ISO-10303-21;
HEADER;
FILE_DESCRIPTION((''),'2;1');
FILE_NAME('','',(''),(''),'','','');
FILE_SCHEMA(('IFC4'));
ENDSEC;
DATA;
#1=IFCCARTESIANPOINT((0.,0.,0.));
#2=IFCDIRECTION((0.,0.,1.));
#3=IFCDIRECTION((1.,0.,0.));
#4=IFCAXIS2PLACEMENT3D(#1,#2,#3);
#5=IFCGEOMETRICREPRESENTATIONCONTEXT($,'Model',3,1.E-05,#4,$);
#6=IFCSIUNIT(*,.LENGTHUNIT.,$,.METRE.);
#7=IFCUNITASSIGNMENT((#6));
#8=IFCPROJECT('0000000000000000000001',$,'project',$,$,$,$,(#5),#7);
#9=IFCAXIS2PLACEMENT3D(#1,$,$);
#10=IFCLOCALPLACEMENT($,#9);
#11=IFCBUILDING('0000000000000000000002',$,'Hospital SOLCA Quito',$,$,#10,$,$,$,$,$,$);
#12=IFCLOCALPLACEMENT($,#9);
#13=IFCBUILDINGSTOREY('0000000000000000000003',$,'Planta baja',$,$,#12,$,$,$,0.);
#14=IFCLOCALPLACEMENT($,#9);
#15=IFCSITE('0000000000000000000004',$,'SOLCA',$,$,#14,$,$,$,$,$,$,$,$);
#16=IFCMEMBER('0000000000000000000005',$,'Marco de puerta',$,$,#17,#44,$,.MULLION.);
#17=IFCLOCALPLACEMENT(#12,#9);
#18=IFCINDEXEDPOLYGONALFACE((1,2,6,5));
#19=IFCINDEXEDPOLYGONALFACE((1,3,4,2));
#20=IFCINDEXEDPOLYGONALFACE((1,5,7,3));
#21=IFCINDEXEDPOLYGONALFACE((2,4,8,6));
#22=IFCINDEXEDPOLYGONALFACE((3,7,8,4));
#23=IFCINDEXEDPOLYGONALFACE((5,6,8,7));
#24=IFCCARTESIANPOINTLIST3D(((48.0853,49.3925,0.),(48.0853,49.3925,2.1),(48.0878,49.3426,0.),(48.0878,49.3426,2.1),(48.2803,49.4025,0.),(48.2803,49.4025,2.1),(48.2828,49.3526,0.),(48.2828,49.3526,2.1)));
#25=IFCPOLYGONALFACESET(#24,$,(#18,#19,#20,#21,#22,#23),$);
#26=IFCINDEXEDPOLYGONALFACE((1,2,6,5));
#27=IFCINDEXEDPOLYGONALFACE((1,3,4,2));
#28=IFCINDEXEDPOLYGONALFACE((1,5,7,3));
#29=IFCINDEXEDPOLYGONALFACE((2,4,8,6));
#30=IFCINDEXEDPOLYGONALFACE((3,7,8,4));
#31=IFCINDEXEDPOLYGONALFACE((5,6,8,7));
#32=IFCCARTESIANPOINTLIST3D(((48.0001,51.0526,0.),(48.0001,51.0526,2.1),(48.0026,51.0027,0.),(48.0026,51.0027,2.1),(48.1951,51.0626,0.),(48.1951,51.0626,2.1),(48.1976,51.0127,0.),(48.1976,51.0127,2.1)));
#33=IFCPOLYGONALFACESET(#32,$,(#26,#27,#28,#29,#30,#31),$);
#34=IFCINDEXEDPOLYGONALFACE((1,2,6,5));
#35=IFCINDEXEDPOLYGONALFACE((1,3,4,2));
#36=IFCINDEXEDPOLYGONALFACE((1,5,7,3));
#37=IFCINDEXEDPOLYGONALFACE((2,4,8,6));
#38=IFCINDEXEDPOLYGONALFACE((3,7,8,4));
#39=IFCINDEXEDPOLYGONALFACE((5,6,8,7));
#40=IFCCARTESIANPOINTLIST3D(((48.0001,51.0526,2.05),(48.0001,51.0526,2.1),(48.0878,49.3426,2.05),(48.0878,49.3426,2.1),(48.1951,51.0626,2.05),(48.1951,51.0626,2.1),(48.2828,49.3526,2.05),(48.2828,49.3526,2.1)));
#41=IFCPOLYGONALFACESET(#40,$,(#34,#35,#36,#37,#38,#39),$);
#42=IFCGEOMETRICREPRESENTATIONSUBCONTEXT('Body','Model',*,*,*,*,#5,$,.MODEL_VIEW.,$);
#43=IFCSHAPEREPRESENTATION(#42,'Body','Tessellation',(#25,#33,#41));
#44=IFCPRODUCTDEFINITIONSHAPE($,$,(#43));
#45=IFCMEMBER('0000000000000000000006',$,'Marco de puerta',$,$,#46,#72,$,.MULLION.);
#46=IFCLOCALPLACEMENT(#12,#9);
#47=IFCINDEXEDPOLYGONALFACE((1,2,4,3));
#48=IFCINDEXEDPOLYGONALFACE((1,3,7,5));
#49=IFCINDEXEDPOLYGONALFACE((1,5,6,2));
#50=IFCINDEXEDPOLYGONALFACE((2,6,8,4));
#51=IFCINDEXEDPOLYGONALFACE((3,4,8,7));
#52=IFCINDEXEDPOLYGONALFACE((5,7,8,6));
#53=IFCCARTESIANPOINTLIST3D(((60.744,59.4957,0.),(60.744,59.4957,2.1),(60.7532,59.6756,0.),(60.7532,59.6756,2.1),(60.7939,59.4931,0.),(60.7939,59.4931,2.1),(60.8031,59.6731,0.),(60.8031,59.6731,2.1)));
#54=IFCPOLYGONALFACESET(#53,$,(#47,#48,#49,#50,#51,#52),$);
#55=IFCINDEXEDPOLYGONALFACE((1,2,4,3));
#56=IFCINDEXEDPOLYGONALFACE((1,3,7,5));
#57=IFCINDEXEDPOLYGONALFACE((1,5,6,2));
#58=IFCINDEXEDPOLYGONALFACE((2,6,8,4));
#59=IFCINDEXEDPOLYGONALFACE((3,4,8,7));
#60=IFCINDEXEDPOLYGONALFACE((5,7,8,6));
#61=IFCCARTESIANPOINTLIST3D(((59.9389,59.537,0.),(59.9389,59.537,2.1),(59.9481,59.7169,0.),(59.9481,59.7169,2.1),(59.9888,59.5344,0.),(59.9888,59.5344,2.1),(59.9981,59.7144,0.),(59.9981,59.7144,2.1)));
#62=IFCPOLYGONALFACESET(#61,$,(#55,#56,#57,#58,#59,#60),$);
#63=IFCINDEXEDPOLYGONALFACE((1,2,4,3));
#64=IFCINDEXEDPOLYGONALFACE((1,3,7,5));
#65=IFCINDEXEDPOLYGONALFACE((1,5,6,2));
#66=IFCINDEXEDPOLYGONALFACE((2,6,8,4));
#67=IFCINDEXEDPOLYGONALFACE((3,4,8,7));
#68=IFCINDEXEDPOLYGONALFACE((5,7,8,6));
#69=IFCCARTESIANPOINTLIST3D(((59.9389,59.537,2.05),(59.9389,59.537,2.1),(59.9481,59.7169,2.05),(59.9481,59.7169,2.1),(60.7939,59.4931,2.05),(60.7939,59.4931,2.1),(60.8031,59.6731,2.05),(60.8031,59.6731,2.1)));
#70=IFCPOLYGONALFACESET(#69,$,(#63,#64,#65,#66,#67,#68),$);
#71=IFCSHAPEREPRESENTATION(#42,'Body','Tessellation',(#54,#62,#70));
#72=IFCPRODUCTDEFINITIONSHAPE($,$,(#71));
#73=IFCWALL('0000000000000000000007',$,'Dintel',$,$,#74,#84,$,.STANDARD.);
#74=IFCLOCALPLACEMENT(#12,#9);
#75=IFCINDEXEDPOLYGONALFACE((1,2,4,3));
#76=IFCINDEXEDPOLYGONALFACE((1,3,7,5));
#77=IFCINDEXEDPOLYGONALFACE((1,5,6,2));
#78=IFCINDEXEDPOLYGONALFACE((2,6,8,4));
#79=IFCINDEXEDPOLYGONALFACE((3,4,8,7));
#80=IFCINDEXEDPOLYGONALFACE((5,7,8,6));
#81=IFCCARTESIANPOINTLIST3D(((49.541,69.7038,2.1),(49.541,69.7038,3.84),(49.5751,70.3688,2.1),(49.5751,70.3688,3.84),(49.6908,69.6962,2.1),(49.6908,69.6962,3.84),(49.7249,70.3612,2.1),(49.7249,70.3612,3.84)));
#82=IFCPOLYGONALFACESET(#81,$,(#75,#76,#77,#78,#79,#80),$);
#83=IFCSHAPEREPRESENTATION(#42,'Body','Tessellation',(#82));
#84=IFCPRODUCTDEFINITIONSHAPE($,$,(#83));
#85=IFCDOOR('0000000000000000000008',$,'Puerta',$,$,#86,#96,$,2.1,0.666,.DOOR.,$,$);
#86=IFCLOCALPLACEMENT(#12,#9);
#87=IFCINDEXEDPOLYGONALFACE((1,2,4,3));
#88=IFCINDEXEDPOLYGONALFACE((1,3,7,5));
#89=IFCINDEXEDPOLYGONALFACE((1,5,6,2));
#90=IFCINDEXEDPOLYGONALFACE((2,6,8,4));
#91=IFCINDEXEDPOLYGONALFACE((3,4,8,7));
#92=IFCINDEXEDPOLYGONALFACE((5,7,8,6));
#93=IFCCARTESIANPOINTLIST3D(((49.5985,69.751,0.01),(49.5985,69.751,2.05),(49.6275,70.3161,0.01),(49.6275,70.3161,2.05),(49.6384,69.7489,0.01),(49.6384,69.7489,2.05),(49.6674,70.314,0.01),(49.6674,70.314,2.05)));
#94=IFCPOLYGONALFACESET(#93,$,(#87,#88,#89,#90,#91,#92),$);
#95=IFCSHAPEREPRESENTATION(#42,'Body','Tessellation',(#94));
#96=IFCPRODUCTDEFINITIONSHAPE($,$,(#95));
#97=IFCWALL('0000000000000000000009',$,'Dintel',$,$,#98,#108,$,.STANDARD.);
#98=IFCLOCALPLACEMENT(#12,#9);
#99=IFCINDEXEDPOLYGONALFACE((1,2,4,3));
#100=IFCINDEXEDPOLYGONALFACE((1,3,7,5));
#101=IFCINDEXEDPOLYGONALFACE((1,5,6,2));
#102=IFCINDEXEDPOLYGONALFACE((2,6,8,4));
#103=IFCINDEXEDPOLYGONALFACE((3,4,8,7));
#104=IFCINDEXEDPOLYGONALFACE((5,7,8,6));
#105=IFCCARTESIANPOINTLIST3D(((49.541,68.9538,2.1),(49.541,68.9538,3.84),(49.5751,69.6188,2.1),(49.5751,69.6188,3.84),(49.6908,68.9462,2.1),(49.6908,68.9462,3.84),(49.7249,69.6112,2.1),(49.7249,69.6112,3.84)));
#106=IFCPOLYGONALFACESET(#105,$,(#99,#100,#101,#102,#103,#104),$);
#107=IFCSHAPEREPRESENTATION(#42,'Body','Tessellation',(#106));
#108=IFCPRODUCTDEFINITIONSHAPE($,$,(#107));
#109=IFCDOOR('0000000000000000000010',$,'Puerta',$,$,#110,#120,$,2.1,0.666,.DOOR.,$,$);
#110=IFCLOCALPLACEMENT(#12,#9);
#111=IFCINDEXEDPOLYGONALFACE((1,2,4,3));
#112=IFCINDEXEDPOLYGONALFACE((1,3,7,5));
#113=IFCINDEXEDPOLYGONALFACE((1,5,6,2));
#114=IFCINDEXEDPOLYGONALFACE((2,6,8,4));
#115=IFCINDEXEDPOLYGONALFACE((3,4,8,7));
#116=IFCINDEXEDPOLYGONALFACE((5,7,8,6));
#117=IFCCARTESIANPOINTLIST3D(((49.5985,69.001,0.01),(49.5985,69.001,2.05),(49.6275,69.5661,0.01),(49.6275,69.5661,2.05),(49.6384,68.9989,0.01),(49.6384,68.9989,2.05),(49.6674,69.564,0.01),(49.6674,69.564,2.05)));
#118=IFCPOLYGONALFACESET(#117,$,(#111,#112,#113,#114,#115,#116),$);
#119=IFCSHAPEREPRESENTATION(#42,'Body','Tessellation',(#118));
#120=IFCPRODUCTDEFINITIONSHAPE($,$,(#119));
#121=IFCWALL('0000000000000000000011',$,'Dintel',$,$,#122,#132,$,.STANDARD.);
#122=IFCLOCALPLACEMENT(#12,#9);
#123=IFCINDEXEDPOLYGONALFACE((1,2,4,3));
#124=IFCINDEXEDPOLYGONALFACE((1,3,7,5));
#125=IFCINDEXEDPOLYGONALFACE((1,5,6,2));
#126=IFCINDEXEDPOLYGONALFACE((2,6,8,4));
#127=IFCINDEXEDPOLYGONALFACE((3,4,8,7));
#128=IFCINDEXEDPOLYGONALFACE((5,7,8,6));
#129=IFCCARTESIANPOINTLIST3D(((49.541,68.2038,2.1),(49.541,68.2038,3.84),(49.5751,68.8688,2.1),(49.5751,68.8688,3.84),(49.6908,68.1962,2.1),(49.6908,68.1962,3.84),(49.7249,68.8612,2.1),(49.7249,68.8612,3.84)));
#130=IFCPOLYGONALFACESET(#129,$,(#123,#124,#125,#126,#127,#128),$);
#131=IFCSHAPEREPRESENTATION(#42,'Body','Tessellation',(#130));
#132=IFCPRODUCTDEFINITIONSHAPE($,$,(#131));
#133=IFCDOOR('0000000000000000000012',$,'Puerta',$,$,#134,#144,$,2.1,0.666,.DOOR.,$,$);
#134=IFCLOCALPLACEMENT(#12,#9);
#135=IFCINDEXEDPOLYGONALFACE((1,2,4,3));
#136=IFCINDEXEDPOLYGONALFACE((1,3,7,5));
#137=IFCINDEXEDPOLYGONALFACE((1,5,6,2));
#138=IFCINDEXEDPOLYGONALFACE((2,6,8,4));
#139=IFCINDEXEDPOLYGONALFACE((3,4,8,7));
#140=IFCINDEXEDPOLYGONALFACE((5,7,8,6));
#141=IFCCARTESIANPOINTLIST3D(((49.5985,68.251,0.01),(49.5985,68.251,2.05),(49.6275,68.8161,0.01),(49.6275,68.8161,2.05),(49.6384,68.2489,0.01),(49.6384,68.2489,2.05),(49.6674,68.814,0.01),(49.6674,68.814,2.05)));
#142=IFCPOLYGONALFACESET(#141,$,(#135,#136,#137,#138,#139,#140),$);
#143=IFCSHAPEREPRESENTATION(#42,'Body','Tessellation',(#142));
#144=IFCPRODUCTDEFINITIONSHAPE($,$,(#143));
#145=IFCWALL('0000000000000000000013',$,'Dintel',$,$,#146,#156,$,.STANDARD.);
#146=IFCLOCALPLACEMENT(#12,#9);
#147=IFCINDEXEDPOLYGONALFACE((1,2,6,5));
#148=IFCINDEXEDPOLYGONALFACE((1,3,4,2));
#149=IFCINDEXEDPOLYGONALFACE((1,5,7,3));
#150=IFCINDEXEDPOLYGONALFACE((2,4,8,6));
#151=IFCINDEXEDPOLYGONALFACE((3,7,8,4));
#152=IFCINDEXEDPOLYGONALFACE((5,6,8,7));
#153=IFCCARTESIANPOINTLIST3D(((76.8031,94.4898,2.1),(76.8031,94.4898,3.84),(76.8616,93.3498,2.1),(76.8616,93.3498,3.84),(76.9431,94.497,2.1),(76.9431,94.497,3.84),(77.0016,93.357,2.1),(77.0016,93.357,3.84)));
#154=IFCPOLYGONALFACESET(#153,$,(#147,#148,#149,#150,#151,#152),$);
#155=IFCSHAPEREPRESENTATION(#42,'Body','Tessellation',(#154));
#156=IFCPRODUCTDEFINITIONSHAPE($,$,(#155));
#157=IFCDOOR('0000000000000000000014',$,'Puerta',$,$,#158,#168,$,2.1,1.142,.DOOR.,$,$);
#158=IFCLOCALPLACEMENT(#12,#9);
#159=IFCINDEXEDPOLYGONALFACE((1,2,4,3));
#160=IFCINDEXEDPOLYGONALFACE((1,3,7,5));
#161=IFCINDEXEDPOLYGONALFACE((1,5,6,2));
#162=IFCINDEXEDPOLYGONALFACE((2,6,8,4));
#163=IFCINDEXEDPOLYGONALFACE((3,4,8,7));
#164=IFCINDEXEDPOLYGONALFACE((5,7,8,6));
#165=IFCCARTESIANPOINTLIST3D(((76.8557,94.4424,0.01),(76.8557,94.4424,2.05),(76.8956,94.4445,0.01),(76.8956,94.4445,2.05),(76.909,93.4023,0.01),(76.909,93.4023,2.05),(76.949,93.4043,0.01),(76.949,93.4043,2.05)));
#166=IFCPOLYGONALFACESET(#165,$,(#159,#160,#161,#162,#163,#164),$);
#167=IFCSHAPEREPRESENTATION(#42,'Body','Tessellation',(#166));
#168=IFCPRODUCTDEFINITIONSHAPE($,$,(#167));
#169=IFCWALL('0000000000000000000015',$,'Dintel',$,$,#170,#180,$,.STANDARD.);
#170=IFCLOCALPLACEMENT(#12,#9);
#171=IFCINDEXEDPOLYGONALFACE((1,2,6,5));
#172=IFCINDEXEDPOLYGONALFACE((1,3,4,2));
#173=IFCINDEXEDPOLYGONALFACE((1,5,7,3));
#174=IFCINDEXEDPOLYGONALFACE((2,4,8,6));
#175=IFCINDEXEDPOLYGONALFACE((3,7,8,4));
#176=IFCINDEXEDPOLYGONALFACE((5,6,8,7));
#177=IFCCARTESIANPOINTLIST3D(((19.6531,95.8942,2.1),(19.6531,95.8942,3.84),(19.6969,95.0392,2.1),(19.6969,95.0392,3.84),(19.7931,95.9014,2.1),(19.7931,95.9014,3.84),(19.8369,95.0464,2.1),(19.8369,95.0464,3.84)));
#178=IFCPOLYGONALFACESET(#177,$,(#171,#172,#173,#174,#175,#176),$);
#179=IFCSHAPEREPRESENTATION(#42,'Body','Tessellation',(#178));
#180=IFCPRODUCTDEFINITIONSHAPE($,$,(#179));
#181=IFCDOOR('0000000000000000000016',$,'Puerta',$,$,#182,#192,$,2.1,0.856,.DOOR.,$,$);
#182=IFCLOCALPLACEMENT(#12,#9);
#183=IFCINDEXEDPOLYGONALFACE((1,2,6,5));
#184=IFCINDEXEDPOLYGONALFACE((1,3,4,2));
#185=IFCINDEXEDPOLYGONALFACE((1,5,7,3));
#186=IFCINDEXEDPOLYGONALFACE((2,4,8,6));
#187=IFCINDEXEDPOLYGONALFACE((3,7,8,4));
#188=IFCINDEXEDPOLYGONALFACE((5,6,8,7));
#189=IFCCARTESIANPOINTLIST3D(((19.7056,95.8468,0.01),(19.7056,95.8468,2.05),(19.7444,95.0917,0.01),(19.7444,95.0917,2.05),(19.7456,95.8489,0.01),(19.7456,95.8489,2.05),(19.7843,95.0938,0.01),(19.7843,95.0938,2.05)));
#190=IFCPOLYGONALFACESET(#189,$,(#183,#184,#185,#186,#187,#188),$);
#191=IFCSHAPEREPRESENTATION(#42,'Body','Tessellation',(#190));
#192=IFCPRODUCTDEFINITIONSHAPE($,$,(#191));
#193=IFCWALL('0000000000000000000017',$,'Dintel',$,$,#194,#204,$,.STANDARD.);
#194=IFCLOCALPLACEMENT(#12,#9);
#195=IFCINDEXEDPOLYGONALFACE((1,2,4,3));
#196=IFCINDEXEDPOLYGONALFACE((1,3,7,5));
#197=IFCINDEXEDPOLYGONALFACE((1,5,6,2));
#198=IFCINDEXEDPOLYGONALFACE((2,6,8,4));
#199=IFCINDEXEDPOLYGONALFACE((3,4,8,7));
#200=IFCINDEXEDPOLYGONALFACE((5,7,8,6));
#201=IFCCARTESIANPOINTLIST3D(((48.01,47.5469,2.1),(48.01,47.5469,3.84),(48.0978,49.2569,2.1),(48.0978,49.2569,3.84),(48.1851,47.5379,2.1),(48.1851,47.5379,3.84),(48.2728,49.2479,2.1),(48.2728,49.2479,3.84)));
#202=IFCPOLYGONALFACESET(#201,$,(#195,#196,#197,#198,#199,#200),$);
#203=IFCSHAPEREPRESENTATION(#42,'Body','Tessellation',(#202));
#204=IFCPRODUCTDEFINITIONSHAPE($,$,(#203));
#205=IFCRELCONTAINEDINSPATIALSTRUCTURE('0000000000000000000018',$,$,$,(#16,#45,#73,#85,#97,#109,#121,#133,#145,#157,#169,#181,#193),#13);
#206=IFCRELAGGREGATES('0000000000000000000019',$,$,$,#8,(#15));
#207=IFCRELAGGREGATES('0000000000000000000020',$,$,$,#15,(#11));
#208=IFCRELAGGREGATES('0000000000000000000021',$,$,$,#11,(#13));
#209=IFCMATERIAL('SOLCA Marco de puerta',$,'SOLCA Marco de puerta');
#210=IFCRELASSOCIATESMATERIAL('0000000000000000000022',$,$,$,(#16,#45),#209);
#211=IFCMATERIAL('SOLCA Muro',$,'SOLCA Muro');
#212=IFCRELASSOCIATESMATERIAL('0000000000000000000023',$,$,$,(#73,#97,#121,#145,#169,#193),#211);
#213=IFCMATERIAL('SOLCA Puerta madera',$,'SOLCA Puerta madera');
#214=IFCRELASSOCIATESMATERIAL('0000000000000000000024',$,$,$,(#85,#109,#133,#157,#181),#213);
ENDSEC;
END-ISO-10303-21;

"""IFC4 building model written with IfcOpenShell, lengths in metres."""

from ifc_helpers import new_model, si_unit, frame, origin, origin_with_axes, place, context, subcontext, project, spatial, polyline, outline, extrude, material, element, save


model = new_model("IFC4")

# Units and contexts
model_context = context("Model", 3, precision=1e-05, world=origin_with_axes())
body_context = subcontext(model_context, "Body", "Model", "MODEL_VIEW")
ifc_project = project(units=[si_unit("LENGTHUNIT", "METRE")], contexts=[model_context])

# Site, building, storey
site_placement = place(None, origin())
site = spatial("IfcSite", under=ifc_project, at=site_placement, Name="SOLCA")
building_placement = place(None, origin())
building = spatial("IfcBuilding", under=site, at=building_placement, Name="Hospital SOLCA Quito")
storey_placement = place(None, origin())
storey = spatial("IfcBuildingStorey", under=building, at=storey_placement, Name="Planta baja", Elevation=0.0)

# Members
ifc_material_1 = material(Name="SOLCA Marco de puerta", Category="SOLCA Marco de puerta")
member_1_placement = place(storey_placement, origin_with_axes())
element("IfcMember", 1, at=member_1_placement, inside=storey, material=ifc_material_1, Name="Marco de puerta", PredefinedType="MULLION", context=body_context, shape_type="SweptSolid", body=[
    extrude(outline(polyline([(48.2828, 49.3526), (48.2803, 49.4025), (48.0853, 49.3925), (48.0878, 49.3426), (48.2828, 49.3526)])), origin_with_axes(), (0.0, 0.0, 1.0), 2.1),
    extrude(outline(polyline([(48.1976, 51.0127), (48.1951, 51.0626), (48.0001, 51.0526), (48.0026, 51.0027), (48.1976, 51.0127)])), origin_with_axes(), (0.0, 0.0, 1.0), 2.1),
    extrude(outline(polyline([(48.2828, 49.3526), (48.1951, 51.0626), (48.0001, 51.0526), (48.0878, 49.3426), (48.2828, 49.3526)])), frame((0.0, 0.0, 2.05), z_axis=(0.0, 0.0, 1.0), x_axis=(1.0, 0.0, 0.0)), (0.0, 0.0, 1.0), 0.05),
])
member_2_placement = place(storey_placement, origin_with_axes())
element("IfcMember", 2, at=member_2_placement, inside=storey, material=ifc_material_1, Name="Marco de puerta", PredefinedType="MULLION", context=body_context, shape_type="SweptSolid", body=[
    extrude(outline(polyline([(60.8031, 59.6731), (60.7532, 59.6756), (60.744, 59.4957), (60.7939, 59.4931), (60.8031, 59.6731)])), origin_with_axes(), (0.0, 0.0, 1.0), 2.1),
    extrude(outline(polyline([(59.9981, 59.7144), (59.9481, 59.7169), (59.9389, 59.537), (59.9888, 59.5344), (59.9981, 59.7144)])), origin_with_axes(), (0.0, 0.0, 1.0), 2.1),
    extrude(outline(polyline([(60.8031, 59.6731), (59.9481, 59.7169), (59.9389, 59.537), (60.7939, 59.4931), (60.8031, 59.6731)])), frame((0.0, 0.0, 2.05), z_axis=(0.0, 0.0, 1.0), x_axis=(1.0, 0.0, 0.0)), (0.0, 0.0, 1.0), 0.05),
])

# Wall
ifc_material_2 = material(Name="SOLCA Muro", Category="SOLCA Muro")
wall_1_placement = place(storey_placement, origin_with_axes())
element("IfcWall", 3, at=wall_1_placement, inside=storey, material=ifc_material_2, Name="Dintel", PredefinedType="STANDARD", context=body_context, shape_type="SweptSolid", body=[
    extrude(outline(polyline([(49.5751, 70.3688), (49.541, 69.7038), (49.6908, 69.6962), (49.7249, 70.3612), (49.5751, 70.3688)])), frame((0.0, 0.0, 2.1), z_axis=(0.0, 0.0, 1.0), x_axis=(1.0, 0.0, 0.0)), (0.0, 0.0, 1.0), 1.74),
])

# Door
ifc_material_3 = material(Name="SOLCA Puerta madera", Category="SOLCA Puerta madera")
door_1_placement = place(storey_placement, origin_with_axes())
element("IfcDoor", 4, at=door_1_placement, inside=storey, material=ifc_material_3, Name="Puerta", OverallHeight=2.1, OverallWidth=0.666, PredefinedType="DOOR", context=body_context, shape_type="SweptSolid", body=[
    extrude(outline(polyline([(49.6275, 70.3161), (49.5985, 69.751), (49.6384, 69.7489), (49.6674, 70.314), (49.6275, 70.3161)])), frame((0.0, 0.0, 0.01), z_axis=(0.0, 0.0, 1.0), x_axis=(1.0, 0.0, 0.0)), (0.0, 0.0, 1.0), 2.04),
])

# Wall
wall_2_placement = place(storey_placement, origin_with_axes())
element("IfcWall", 5, at=wall_2_placement, inside=storey, material=ifc_material_2, Name="Dintel", PredefinedType="STANDARD", context=body_context, shape_type="SweptSolid", body=[
    extrude(outline(polyline([(49.5751, 69.6188), (49.541, 68.9538), (49.6908, 68.9462), (49.7249, 69.6112), (49.5751, 69.6188)])), frame((0.0, 0.0, 2.1), z_axis=(0.0, 0.0, 1.0), x_axis=(1.0, 0.0, 0.0)), (0.0, 0.0, 1.0), 1.74),
])

# Door
door_2_placement = place(storey_placement, origin_with_axes())
element("IfcDoor", 6, at=door_2_placement, inside=storey, material=ifc_material_3, Name="Puerta", OverallHeight=2.1, OverallWidth=0.666, PredefinedType="DOOR", context=body_context, shape_type="SweptSolid", body=[
    extrude(outline(polyline([(49.6275, 69.5661), (49.5985, 69.001), (49.6384, 68.9989), (49.6674, 69.564), (49.6275, 69.5661)])), frame((0.0, 0.0, 0.01), z_axis=(0.0, 0.0, 1.0), x_axis=(1.0, 0.0, 0.0)), (0.0, 0.0, 1.0), 2.04),
])

# Wall
wall_3_placement = place(storey_placement, origin_with_axes())
element("IfcWall", 7, at=wall_3_placement, inside=storey, material=ifc_material_2, Name="Dintel", PredefinedType="STANDARD", context=body_context, shape_type="SweptSolid", body=[
    extrude(outline(polyline([(49.5751, 68.8688), (49.541, 68.2038), (49.6908, 68.1962), (49.7249, 68.8612), (49.5751, 68.8688)])), frame((0.0, 0.0, 2.1), z_axis=(0.0, 0.0, 1.0), x_axis=(1.0, 0.0, 0.0)), (0.0, 0.0, 1.0), 1.74),
])

# Door
door_3_placement = place(storey_placement, origin_with_axes())
element("IfcDoor", 8, at=door_3_placement, inside=storey, material=ifc_material_3, Name="Puerta", OverallHeight=2.1, OverallWidth=0.666, PredefinedType="DOOR", context=body_context, shape_type="SweptSolid", body=[
    extrude(outline(polyline([(49.6275, 68.8161), (49.5985, 68.251), (49.6384, 68.2489), (49.6674, 68.814), (49.6275, 68.8161)])), frame((0.0, 0.0, 0.01), z_axis=(0.0, 0.0, 1.0), x_axis=(1.0, 0.0, 0.0)), (0.0, 0.0, 1.0), 2.04),
])

# Wall
wall_4_placement = place(storey_placement, origin_with_axes())
element("IfcWall", 9, at=wall_4_placement, inside=storey, material=ifc_material_2, Name="Dintel", PredefinedType="STANDARD", context=body_context, shape_type="SweptSolid", body=[
    extrude(outline(polyline([(76.8031, 94.4898), (76.8616, 93.3498), (77.0016, 93.357), (76.9431, 94.497), (76.8031, 94.4898)])), frame((0.0, 0.0, 2.1), z_axis=(0.0, 0.0, 1.0), x_axis=(1.0, 0.0, 0.0)), (0.0, 0.0, 1.0), 1.74),
])

# Door
door_4_placement = place(storey_placement, origin_with_axes())
element("IfcDoor", 10, at=door_4_placement, inside=storey, material=ifc_material_3, Name="Puerta", OverallHeight=2.1, OverallWidth=1.142, PredefinedType="DOOR", context=body_context, shape_type="SweptSolid", body=[
    extrude(outline(polyline([(76.8557, 94.4424), (76.909, 93.4023), (76.949, 93.4043), (76.8956, 94.4445), (76.8557, 94.4424)])), frame((0.0, 0.0, 0.01), z_axis=(0.0, 0.0, 1.0), x_axis=(1.0, 0.0, 0.0)), (0.0, 0.0, 1.0), 2.04),
])

# Wall
wall_5_placement = place(storey_placement, origin_with_axes())
element("IfcWall", 11, at=wall_5_placement, inside=storey, material=ifc_material_2, Name="Dintel", PredefinedType="STANDARD", context=body_context, shape_type="SweptSolid", body=[
    extrude(outline(polyline([(19.8369, 95.0464), (19.7931, 95.9014), (19.6531, 95.8942), (19.6969, 95.0392), (19.8369, 95.0464)])), frame((0.0, 0.0, 2.1), z_axis=(0.0, 0.0, 1.0), x_axis=(1.0, 0.0, 0.0)), (0.0, 0.0, 1.0), 1.74),
])

# Door
door_5_placement = place(storey_placement, origin_with_axes())
element("IfcDoor", 12, at=door_5_placement, inside=storey, material=ifc_material_3, Name="Puerta", OverallHeight=2.1, OverallWidth=0.856, PredefinedType="DOOR", context=body_context, shape_type="SweptSolid", body=[
    extrude(outline(polyline([(19.7843, 95.0938), (19.7456, 95.8489), (19.7056, 95.8468), (19.7444, 95.0917), (19.7843, 95.0938)])), frame((0.0, 0.0, 0.01), z_axis=(0.0, 0.0, 1.0), x_axis=(1.0, 0.0, 0.0)), (0.0, 0.0, 1.0), 2.04),
])

# Wall
wall_6_placement = place(storey_placement, origin_with_axes())
element("IfcWall", 13, at=wall_6_placement, inside=storey, material=ifc_material_2, Name="Dintel", PredefinedType="STANDARD", context=body_context, shape_type="SweptSolid", body=[
    extrude(outline(polyline([(48.0978, 49.2569), (48.01, 47.5469), (48.1851, 47.5379), (48.2728, 49.2479), (48.0978, 49.2569)])), frame((0.0, 0.0, 2.1), z_axis=(0.0, 0.0, 1.0), x_axis=(1.0, 0.0, 0.0)), (0.0, 0.0, 1.0), 1.74),
])

save(model, "model.ifc")
